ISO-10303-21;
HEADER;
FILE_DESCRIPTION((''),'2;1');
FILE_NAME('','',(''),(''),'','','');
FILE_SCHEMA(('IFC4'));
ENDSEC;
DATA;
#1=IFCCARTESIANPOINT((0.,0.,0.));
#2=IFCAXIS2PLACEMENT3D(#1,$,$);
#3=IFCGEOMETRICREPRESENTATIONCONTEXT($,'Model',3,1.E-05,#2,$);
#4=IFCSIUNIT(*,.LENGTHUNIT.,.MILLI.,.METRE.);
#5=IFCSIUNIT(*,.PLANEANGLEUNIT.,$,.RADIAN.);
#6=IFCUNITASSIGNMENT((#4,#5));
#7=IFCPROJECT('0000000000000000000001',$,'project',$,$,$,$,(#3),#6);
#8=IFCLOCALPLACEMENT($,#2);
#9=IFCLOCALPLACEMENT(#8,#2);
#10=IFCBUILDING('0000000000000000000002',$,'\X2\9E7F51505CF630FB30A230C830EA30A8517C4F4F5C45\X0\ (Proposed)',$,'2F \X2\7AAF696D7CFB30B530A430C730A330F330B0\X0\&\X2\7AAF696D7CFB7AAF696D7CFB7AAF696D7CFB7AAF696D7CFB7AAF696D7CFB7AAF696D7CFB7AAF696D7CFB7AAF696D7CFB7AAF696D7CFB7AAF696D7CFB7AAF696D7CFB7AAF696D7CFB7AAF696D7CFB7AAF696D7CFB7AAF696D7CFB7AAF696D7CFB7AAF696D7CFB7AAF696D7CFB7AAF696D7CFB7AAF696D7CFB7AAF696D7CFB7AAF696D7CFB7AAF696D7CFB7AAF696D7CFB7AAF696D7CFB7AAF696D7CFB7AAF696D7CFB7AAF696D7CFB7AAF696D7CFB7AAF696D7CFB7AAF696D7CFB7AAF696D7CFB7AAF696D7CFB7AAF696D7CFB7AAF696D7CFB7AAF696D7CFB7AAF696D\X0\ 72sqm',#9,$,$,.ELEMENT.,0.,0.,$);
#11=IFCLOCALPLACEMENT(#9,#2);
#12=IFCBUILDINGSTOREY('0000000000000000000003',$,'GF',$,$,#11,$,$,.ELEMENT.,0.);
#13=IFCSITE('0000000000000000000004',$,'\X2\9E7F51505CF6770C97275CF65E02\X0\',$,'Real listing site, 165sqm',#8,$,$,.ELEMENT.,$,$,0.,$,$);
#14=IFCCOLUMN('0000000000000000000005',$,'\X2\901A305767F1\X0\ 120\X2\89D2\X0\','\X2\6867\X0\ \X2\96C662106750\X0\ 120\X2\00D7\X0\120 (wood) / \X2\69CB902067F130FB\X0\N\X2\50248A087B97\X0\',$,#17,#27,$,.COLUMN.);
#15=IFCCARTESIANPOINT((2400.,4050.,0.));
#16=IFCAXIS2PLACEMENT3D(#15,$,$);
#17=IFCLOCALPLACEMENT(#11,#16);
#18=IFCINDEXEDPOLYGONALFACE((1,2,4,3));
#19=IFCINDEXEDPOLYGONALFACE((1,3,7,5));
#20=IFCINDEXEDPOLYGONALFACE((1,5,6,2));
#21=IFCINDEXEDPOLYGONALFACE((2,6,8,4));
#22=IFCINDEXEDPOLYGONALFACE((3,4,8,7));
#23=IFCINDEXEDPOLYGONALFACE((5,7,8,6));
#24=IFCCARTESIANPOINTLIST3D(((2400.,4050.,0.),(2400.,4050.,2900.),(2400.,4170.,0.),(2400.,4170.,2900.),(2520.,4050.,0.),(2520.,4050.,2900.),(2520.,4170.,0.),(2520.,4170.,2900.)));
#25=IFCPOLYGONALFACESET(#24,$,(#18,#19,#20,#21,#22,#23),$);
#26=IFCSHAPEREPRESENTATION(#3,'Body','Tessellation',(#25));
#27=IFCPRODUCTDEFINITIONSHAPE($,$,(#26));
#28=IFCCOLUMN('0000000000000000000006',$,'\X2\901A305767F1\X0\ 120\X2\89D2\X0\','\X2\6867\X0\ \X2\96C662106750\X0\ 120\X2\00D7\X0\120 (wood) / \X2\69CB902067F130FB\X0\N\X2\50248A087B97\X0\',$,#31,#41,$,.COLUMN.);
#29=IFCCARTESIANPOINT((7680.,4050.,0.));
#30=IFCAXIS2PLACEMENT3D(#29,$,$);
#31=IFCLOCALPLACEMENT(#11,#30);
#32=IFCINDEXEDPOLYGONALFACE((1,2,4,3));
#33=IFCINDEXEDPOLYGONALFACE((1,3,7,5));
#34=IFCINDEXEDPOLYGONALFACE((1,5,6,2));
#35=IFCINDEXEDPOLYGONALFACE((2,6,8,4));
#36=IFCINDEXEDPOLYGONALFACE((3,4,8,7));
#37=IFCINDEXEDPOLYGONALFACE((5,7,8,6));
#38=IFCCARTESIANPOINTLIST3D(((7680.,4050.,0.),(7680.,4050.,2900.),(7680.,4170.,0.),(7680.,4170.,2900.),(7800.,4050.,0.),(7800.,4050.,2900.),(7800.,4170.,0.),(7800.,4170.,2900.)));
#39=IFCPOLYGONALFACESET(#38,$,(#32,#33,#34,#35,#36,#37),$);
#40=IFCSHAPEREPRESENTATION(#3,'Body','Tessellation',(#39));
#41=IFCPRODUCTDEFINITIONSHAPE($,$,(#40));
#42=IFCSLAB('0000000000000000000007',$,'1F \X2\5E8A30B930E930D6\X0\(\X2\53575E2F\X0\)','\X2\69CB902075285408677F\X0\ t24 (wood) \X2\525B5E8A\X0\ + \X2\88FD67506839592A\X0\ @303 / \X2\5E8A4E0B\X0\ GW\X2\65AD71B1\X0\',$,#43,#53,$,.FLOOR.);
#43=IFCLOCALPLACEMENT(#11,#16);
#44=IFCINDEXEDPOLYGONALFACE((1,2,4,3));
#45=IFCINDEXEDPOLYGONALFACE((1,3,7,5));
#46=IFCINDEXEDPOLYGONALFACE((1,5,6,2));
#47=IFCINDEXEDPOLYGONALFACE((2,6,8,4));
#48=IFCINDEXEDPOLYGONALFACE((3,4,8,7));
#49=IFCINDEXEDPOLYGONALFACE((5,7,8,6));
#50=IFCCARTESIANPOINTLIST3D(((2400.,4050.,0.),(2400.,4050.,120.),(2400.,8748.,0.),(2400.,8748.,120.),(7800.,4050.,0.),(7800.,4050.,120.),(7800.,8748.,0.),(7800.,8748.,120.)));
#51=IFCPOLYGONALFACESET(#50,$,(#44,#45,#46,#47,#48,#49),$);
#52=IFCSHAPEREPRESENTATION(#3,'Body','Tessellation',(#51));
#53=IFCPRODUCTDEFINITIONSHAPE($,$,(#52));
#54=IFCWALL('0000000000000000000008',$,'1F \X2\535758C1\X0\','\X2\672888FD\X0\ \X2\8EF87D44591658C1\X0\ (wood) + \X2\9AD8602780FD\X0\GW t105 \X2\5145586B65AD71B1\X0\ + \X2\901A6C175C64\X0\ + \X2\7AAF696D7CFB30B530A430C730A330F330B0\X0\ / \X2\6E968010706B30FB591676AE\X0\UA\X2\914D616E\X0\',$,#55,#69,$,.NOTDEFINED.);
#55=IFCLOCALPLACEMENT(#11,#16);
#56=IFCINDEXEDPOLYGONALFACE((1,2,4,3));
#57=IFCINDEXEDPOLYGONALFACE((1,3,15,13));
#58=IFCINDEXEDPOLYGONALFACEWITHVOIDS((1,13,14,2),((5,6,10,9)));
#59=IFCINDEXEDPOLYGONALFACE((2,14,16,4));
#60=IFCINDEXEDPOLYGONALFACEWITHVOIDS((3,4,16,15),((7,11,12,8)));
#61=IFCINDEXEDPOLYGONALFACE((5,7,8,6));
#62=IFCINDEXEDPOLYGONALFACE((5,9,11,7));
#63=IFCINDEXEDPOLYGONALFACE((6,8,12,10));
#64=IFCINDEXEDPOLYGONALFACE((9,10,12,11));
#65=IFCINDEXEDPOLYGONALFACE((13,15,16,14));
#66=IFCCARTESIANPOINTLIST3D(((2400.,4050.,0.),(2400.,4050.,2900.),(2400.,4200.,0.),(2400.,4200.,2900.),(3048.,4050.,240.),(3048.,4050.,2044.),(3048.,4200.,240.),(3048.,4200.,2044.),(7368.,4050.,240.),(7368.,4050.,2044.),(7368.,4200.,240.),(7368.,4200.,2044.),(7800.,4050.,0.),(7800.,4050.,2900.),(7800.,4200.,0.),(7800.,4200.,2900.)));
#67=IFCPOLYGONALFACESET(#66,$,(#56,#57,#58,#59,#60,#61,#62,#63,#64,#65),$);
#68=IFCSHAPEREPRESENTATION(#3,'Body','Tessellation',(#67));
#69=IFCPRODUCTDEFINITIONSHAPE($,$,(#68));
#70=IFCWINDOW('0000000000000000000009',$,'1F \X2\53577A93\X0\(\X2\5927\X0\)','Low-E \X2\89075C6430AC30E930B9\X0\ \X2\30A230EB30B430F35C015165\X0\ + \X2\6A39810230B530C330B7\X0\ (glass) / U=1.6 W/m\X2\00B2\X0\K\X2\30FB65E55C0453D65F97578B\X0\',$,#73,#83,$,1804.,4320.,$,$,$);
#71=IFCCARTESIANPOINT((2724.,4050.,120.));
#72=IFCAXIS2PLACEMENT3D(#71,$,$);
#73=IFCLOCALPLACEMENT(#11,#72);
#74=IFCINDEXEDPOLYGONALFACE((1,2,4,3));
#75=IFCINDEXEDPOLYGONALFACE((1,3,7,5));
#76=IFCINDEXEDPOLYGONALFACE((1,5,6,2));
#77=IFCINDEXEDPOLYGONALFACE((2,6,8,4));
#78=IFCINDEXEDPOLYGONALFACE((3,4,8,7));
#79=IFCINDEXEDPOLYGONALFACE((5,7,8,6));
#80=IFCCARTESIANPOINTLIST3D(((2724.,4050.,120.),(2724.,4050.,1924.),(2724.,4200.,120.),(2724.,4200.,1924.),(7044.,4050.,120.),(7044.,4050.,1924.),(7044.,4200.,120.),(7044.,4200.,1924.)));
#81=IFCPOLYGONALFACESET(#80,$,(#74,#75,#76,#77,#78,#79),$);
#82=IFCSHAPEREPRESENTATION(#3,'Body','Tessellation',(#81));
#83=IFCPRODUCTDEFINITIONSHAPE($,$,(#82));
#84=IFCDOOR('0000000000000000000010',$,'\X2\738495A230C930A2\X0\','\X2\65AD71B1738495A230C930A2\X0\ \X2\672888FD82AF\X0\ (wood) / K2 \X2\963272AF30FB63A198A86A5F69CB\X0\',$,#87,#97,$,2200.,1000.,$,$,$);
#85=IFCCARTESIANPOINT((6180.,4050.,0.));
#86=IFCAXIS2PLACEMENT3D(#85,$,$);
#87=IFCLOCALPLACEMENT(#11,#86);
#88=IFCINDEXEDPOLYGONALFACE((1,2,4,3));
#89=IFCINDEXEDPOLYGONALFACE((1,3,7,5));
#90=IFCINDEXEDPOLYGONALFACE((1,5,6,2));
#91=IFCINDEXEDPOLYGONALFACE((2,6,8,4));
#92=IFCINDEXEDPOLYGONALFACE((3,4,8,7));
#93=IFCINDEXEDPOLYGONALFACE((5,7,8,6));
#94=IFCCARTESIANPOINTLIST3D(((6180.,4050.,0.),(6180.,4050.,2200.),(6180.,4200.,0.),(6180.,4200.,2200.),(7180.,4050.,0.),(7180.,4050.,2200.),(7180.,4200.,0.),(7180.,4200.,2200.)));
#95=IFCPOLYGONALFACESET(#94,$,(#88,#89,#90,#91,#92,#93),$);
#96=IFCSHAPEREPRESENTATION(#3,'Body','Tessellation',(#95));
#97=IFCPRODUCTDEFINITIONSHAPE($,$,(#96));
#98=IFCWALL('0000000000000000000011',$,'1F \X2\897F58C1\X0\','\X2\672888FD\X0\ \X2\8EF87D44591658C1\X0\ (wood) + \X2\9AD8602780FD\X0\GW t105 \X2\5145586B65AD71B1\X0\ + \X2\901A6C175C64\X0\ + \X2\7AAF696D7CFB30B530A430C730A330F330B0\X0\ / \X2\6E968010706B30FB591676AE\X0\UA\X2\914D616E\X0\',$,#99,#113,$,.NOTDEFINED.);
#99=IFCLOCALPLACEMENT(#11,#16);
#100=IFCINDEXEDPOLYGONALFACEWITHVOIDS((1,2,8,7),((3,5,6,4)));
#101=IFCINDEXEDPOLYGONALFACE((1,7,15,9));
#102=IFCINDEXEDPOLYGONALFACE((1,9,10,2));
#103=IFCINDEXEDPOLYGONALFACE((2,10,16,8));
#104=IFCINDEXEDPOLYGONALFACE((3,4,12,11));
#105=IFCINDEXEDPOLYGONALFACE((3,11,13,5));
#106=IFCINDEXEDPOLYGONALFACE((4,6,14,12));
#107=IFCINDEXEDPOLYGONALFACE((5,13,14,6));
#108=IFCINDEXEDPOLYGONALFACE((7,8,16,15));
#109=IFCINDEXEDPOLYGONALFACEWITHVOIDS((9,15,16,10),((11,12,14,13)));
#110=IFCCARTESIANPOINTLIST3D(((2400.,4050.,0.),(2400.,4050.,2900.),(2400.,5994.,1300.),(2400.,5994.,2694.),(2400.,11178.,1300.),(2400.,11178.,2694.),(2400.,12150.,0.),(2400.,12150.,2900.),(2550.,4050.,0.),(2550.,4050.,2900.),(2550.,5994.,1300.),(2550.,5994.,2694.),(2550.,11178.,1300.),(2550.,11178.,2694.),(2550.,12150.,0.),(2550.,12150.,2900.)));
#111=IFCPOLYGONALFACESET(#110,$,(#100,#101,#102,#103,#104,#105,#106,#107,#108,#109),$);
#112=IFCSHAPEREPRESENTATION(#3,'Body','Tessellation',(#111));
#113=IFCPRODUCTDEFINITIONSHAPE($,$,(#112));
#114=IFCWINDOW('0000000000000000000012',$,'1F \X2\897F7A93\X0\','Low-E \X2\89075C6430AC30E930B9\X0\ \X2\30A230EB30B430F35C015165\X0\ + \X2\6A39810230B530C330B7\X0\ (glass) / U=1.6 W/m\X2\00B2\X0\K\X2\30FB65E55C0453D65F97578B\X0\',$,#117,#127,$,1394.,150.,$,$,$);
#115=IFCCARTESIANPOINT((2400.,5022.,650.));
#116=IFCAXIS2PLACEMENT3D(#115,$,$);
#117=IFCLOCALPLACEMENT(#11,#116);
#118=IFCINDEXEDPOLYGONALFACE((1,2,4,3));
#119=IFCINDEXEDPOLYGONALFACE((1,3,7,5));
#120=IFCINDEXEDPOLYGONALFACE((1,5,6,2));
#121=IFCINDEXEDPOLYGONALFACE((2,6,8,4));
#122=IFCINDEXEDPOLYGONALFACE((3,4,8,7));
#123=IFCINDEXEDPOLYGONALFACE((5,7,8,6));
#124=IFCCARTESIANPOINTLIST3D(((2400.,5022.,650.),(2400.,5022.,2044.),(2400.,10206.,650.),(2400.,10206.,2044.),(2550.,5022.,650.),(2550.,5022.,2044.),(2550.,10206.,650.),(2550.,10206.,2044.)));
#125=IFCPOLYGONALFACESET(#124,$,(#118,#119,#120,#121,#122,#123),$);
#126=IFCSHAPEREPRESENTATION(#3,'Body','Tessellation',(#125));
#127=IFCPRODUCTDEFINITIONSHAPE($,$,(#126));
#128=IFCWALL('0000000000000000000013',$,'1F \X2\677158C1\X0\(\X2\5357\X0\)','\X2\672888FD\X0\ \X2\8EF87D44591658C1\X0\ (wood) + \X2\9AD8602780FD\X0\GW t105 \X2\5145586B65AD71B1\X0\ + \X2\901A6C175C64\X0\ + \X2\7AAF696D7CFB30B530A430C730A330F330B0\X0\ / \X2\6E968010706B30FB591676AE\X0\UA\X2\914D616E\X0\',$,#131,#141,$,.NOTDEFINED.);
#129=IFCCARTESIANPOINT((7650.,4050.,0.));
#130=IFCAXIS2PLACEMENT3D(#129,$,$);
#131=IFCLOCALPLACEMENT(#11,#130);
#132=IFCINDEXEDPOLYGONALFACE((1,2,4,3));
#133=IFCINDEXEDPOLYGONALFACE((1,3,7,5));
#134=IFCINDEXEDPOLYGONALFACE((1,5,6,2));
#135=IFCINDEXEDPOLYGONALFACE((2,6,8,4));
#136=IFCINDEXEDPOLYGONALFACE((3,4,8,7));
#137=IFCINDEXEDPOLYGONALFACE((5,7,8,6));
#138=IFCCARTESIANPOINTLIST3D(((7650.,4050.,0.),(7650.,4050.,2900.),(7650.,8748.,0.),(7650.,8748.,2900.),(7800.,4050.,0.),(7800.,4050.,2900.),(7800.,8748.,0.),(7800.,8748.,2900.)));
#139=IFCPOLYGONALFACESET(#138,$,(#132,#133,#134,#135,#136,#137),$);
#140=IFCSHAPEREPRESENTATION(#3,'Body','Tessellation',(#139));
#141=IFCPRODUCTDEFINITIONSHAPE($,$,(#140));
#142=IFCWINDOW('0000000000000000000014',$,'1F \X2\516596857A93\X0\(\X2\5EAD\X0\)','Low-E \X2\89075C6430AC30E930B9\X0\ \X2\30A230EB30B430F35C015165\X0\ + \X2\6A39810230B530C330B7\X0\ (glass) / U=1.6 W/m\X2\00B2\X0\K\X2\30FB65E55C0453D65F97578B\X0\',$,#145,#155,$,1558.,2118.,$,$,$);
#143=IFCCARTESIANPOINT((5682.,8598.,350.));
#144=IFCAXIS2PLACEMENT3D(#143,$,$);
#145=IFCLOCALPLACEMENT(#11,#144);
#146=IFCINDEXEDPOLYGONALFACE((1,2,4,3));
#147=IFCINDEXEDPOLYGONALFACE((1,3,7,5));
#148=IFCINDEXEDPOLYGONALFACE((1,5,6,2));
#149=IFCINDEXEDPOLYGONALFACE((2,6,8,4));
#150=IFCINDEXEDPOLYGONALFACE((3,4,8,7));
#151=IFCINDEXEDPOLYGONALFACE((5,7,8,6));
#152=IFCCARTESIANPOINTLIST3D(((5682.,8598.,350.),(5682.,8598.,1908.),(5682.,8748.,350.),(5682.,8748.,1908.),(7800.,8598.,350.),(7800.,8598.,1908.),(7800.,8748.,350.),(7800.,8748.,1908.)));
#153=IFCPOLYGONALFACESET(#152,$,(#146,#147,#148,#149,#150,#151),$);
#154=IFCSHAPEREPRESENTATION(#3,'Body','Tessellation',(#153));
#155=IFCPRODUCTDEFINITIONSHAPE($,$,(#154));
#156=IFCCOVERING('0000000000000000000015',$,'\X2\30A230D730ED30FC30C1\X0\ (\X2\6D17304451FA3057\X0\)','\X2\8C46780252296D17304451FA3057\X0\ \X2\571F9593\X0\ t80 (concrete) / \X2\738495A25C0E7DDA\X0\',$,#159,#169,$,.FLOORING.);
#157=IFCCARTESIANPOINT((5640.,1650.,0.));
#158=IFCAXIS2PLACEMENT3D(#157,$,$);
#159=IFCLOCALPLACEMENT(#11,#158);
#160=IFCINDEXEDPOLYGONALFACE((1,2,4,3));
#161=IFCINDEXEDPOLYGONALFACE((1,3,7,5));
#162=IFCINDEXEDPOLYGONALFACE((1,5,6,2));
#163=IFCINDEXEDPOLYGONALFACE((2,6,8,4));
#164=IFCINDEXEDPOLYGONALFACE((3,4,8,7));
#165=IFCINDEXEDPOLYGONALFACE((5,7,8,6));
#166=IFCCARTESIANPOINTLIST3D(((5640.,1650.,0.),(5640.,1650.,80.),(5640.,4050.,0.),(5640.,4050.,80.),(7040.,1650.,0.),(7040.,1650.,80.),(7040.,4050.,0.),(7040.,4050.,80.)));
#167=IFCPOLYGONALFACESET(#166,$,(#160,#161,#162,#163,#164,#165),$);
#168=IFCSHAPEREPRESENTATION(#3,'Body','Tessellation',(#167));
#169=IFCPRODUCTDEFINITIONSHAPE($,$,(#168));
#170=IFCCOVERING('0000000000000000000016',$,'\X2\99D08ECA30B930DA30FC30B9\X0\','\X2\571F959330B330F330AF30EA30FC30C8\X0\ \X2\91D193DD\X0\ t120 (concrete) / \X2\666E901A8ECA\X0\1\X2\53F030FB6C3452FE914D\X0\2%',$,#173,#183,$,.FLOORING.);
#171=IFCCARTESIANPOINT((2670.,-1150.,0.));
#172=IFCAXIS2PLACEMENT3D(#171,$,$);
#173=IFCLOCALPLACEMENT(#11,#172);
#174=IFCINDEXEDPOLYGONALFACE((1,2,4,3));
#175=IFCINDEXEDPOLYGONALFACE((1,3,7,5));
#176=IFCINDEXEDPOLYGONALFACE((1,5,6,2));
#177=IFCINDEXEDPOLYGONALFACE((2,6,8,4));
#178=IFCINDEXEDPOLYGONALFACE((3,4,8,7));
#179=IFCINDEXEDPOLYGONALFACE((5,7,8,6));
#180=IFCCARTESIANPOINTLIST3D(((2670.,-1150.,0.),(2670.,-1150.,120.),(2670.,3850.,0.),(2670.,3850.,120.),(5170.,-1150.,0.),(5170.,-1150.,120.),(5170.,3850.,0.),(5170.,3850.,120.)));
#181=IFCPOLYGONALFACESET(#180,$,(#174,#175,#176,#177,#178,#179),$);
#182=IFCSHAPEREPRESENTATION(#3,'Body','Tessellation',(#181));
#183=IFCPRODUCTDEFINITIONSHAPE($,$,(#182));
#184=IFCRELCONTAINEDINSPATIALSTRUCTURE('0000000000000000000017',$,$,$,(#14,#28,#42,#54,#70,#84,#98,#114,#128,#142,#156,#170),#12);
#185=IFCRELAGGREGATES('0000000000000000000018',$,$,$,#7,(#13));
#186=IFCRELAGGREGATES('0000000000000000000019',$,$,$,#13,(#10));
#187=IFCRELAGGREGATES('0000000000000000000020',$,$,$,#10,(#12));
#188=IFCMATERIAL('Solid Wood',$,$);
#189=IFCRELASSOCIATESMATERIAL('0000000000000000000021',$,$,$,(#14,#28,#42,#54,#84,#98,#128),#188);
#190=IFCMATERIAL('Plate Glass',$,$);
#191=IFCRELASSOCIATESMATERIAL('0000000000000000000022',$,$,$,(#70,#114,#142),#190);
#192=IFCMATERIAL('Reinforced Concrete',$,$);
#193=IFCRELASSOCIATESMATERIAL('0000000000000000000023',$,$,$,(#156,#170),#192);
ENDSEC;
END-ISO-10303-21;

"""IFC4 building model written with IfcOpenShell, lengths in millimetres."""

from ifc_helpers import new_model, si_unit, frame, frame_2d, origin, place, context, project, spatial, rectangle, extrude, material, element, fill, save


model = new_model("IFC4")

# Units and contexts
model_context = context("Model", 3, precision=1e-05, world=origin())
ifc_project = project(units=[si_unit("LENGTHUNIT", "METRE", prefix="MILLI"), si_unit("PLANEANGLEUNIT", "RADIAN")], contexts=[model_context])

# Site, building, storey
site_placement = place(None, origin())
site = spatial("IfcSite", under=ifc_project, at=site_placement, Name="鹿児島県霧島市", ObjectType="Real listing site, 165sqm", CompositionType="ELEMENT", RefElevation=0.0)
building_placement = place(site_placement, origin())
building = spatial("IfcBuilding", under=site, at=building_placement, Name="鹿児島・アトリエ兼住居 (Proposed)", ObjectType="2F 窯業系サイディング&窯業系窯業系窯業系窯業系窯業系窯業系窯業系窯業系窯業系窯業系窯業系窯業系窯業系窯業系窯業系窯業系窯業系窯業系窯業系窯業系窯業系窯業系窯業系窯業系窯業系窯業系窯業系窯業系窯業系窯業系窯業系窯業系窯業系窯業系窯業系窯業系窯業 72sqm", CompositionType="ELEMENT", ElevationOfRefHeight=0.0, ElevationOfTerrain=0.0)
storey_placement = place(building_placement, origin())
storey = spatial("IfcBuildingStorey", under=building, at=storey_placement, Name="GF", CompositionType="ELEMENT", Elevation=0.0)

# Columns
ifc_material_1 = material(Name="Solid Wood")
column_1_placement = place(storey_placement, frame((2400.0, 4050.0, 0.0)))
element("IfcColumn", 1, at=column_1_placement, inside=storey, material=ifc_material_1, Name="通し柱 120角", Description="桧 集成材 120×120 (wood) / 構造柱・N値計算", PredefinedType="COLUMN", context=model_context, shape_type="SweptSolid", body=[
    extrude(rectangle(XDim=120.0, YDim=120.0, at=frame_2d((60.0, 60.0))), frame((2400.0, 4050.0, 0.0)), (0.0, 0.0, 1.0), 2900.0),
])
column_2_placement = place(storey_placement, frame((7680.0, 4050.0, 0.0)))
element("IfcColumn", 2, at=column_2_placement, inside=storey, material=ifc_material_1, Name="通し柱 120角", Description="桧 集成材 120×120 (wood) / 構造柱・N値計算", PredefinedType="COLUMN", context=model_context, shape_type="SweptSolid", body=[
    extrude(rectangle(XDim=120.0, YDim=120.0, at=frame_2d((60.0, 60.0))), frame((7680.0, 4050.0, 0.0)), (0.0, 0.0, 1.0), 2900.0),
])

# Slab
ifc_material_2 = material(Name="Reinforced Concrete")
slab_1_placement = place(storey_placement, frame((2400.0, 4050.0, 0.0)))
element("IfcSlab", 3, at=slab_1_placement, inside=storey, material=ifc_material_1, Name="1F 床スラブ(南帯)", Description="構造用合板 t24 (wood) 剛床 + 製材根太 @303 / 床下 GW断熱", PredefinedType="FLOOR", context=model_context, shape_type="SweptSolid", body=[
    extrude(rectangle(XDim=5400.0, YDim=4698.0, at=frame_2d((2700.0, 2349.0))), frame((2400.0, 4050.0, 0.0)), (0.0, 0.0, 1.0), 120.0),
])

# Wall, openings, window, door
wall_1_placement = place(storey_placement, frame((2400.0, 4050.0, 0.0)))
wall_1 = element("IfcWall", 4, at=wall_1_placement, inside=storey, material=ifc_material_1, Name="1F 南壁", Description="木製 軸組外壁 (wood) + 高性能GW t105 充填断熱 + 通気層 + 窯業系サイディング / 準耐火・外皮UA配慮", PredefinedType="NOTDEFINED", context=model_context, shape_type="SweptSolid", body=[
    extrude(rectangle(XDim=5400.0, YDim=150.0, at=frame_2d((2700.0, 75.0))), frame((2400.0, 4050.0, 0.0)), (0.0, 0.0, 1.0), 2900.0),
])
opening_1_placement = place(storey_placement, frame((2724.0, 4050.0, 120.0)))
opening_1 = element("IfcOpeningElement", 5, at=opening_1_placement, cuts=wall_1, PredefinedType="NOTDEFINED", context=model_context, shape_type="SweptSolid", body=[
    extrude(rectangle(XDim=4320.0, YDim=150.0, at=frame_2d((2160.0, 75.0))), frame((2724.0, 4050.0, 120.0)), (0.0, 0.0, 1.0), 1804.0),
])
opening_2_placement = place(storey_placement, frame((6180.0, 4050.0, 0.0)))
opening_2 = element("IfcOpeningElement", 6, at=opening_2_placement, cuts=wall_1, PredefinedType="NOTDEFINED", context=model_context, shape_type="SweptSolid", body=[
    extrude(rectangle(XDim=1000.0, YDim=150.0, at=frame_2d((500.0, 75.0))), frame((6180.0, 4050.0, 0.0)), (0.0, 0.0, 1.0), 2200.0),
])
ifc_material_3 = material(Name="Plate Glass")
window_1_placement = place(storey_placement, frame((2724.0, 4050.0, 120.0)))
window_1 = element("IfcWindow", 7, at=window_1_placement, inside=storey, material=ifc_material_3, Name="1F 南窓(大)", Description="Low-E 複層ガラス アルゴン封入 + 樹脂サッシ (glass) / U=1.6 W/m²K・日射取得型", OverallHeight=1804.0, OverallWidth=4320.0, context=model_context, shape_type="SweptSolid", body=[
    extrude(rectangle(XDim=4320.0, YDim=150.0, at=frame_2d((2160.0, 75.0))), frame((2724.0, 4050.0, 120.0)), (0.0, 0.0, 1.0), 1804.0),
])
fill(opening_1, window_1)
door_1_placement = place(storey_placement, frame((6180.0, 4050.0, 0.0)))
door_1 = element("IfcDoor", 8, at=door_1_placement, inside=storey, material=ifc_material_1, Name="玄関ドア", Description="断熱玄関ドア 木製芯 (wood) / K2 防犯・採風機構", OverallHeight=2200.0, OverallWidth=1000.0, context=model_context, shape_type="SweptSolid", body=[
    extrude(rectangle(XDim=1000.0, YDim=150.0, at=frame_2d((500.0, 75.0))), frame((6180.0, 4050.0, 0.0)), (0.0, 0.0, 1.0), 2200.0),
])
fill(opening_2, door_1)

# Walls, openings, windows
wall_2_placement = place(storey_placement, frame((2400.0, 4050.0, 0.0)))
wall_2 = element("IfcWall", 9, at=wall_2_placement, inside=storey, material=ifc_material_1, Name="1F 西壁", Description="木製 軸組外壁 (wood) + 高性能GW t105 充填断熱 + 通気層 + 窯業系サイディング / 準耐火・外皮UA配慮", PredefinedType="NOTDEFINED", context=model_context, shape_type="SweptSolid", body=[
    extrude(rectangle(XDim=150.0, YDim=8100.0, at=frame_2d((75.0, 4050.0))), frame((2400.0, 4050.0, 0.0)), (0.0, 0.0, 1.0), 2900.0),
])
opening_3_placement = place(storey_placement, frame((2400.0, 5022.0, 650.0)))
opening_3 = element("IfcOpeningElement", 10, at=opening_3_placement, cuts=wall_2, PredefinedType="NOTDEFINED", context=model_context, shape_type="SweptSolid", body=[
    extrude(rectangle(XDim=150.0, YDim=5184.0, at=frame_2d((75.0, 2592.0))), frame((2400.0, 5022.0, 650.0)), (0.0, 0.0, 1.0), 1394.0),
])
window_2_placement = place(storey_placement, frame((2400.0, 5022.0, 650.0)))
window_2 = element("IfcWindow", 11, at=window_2_placement, inside=storey, material=ifc_material_3, Name="1F 西窓", Description="Low-E 複層ガラス アルゴン封入 + 樹脂サッシ (glass) / U=1.6 W/m²K・日射取得型", OverallHeight=1394.0, OverallWidth=150.0, context=model_context, shape_type="SweptSolid", body=[
    extrude(rectangle(XDim=150.0, YDim=5184.0, at=frame_2d((75.0, 2592.0))), frame((2400.0, 5022.0, 650.0)), (0.0, 0.0, 1.0), 1394.0),
])
fill(opening_3, window_2)
wall_3_placement = place(storey_placement, frame((7650.0, 4050.0, 0.0)))
wall_3 = element("IfcWall", 12, at=wall_3_placement, inside=storey, material=ifc_material_1, Name="1F 東壁(南)", Description="木製 軸組外壁 (wood) + 高性能GW t105 充填断熱 + 通気層 + 窯業系サイディング / 準耐火・外皮UA配慮", PredefinedType="NOTDEFINED", context=model_context, shape_type="SweptSolid", body=[
    extrude(rectangle(XDim=150.0, YDim=4698.0, at=frame_2d((75.0, 2349.0))), frame((7650.0, 4050.0, 0.0)), (0.0, 0.0, 1.0), 2900.0),
])
opening_4_placement = place(storey_placement, frame((5682.0, 8598.0, 350.0)))
opening_4 = element("IfcOpeningElement", 13, at=opening_4_placement, cuts=wall_3, PredefinedType="NOTDEFINED", context=model_context, shape_type="SweptSolid", body=[
    extrude(rectangle(XDim=2118.0, YDim=150.0, at=frame_2d((1059.0, 75.0))), frame((5682.0, 8598.0, 350.0)), (0.0, 0.0, 1.0), 1558.0),
])
window_3_placement = place(storey_placement, frame((5682.0, 8598.0, 350.0)))
window_3 = element("IfcWindow", 14, at=window_3_placement, inside=storey, material=ifc_material_3, Name="1F 入隅窓(庭)", Description="Low-E 複層ガラス アルゴン封入 + 樹脂サッシ (glass) / U=1.6 W/m²K・日射取得型", OverallHeight=1558.0, OverallWidth=2118.0, context=model_context, shape_type="SweptSolid", body=[
    extrude(rectangle(XDim=2118.0, YDim=150.0, at=frame_2d((1059.0, 75.0))), frame((5682.0, 8598.0, 350.0)), (0.0, 0.0, 1.0), 1558.0),
])
fill(opening_4, window_3)

# Coverings
covering_1_placement = place(storey_placement, frame((5640.0, 1650.0, 0.0)))
element("IfcCovering", 15, at=covering_1_placement, inside=storey, material=ifc_material_2, Name="アプローチ (洗い出し)", Description="豆砂利洗い出し 土間 t80 (concrete) / 玄関導線", PredefinedType="FLOORING", context=model_context, shape_type="SweptSolid", body=[
    extrude(rectangle(XDim=1400.0, YDim=2400.0, at=frame_2d((700.0, 1200.0))), frame((5640.0, 1650.0, 0.0)), (0.0, 0.0, 1.0), 80.0),
])
covering_2_placement = place(storey_placement, frame((2670.0, -1150.0, 0.0)))
element("IfcCovering", 16, at=covering_2_placement, inside=storey, material=ifc_material_2, Name="駐車スペース", Description="土間コンクリート 金鏝 t120 (concrete) / 普通車1台・水勾配2%", PredefinedType="FLOORING", context=model_context, shape_type="SweptSolid", body=[
    extrude(rectangle(XDim=2500.0, YDim=5000.0, at=frame_2d((1250.0, 2500.0))), frame((2670.0, -1150.0, 0.0)), (0.0, 0.0, 1.0), 120.0),
])

save(model, "model.ifc")
